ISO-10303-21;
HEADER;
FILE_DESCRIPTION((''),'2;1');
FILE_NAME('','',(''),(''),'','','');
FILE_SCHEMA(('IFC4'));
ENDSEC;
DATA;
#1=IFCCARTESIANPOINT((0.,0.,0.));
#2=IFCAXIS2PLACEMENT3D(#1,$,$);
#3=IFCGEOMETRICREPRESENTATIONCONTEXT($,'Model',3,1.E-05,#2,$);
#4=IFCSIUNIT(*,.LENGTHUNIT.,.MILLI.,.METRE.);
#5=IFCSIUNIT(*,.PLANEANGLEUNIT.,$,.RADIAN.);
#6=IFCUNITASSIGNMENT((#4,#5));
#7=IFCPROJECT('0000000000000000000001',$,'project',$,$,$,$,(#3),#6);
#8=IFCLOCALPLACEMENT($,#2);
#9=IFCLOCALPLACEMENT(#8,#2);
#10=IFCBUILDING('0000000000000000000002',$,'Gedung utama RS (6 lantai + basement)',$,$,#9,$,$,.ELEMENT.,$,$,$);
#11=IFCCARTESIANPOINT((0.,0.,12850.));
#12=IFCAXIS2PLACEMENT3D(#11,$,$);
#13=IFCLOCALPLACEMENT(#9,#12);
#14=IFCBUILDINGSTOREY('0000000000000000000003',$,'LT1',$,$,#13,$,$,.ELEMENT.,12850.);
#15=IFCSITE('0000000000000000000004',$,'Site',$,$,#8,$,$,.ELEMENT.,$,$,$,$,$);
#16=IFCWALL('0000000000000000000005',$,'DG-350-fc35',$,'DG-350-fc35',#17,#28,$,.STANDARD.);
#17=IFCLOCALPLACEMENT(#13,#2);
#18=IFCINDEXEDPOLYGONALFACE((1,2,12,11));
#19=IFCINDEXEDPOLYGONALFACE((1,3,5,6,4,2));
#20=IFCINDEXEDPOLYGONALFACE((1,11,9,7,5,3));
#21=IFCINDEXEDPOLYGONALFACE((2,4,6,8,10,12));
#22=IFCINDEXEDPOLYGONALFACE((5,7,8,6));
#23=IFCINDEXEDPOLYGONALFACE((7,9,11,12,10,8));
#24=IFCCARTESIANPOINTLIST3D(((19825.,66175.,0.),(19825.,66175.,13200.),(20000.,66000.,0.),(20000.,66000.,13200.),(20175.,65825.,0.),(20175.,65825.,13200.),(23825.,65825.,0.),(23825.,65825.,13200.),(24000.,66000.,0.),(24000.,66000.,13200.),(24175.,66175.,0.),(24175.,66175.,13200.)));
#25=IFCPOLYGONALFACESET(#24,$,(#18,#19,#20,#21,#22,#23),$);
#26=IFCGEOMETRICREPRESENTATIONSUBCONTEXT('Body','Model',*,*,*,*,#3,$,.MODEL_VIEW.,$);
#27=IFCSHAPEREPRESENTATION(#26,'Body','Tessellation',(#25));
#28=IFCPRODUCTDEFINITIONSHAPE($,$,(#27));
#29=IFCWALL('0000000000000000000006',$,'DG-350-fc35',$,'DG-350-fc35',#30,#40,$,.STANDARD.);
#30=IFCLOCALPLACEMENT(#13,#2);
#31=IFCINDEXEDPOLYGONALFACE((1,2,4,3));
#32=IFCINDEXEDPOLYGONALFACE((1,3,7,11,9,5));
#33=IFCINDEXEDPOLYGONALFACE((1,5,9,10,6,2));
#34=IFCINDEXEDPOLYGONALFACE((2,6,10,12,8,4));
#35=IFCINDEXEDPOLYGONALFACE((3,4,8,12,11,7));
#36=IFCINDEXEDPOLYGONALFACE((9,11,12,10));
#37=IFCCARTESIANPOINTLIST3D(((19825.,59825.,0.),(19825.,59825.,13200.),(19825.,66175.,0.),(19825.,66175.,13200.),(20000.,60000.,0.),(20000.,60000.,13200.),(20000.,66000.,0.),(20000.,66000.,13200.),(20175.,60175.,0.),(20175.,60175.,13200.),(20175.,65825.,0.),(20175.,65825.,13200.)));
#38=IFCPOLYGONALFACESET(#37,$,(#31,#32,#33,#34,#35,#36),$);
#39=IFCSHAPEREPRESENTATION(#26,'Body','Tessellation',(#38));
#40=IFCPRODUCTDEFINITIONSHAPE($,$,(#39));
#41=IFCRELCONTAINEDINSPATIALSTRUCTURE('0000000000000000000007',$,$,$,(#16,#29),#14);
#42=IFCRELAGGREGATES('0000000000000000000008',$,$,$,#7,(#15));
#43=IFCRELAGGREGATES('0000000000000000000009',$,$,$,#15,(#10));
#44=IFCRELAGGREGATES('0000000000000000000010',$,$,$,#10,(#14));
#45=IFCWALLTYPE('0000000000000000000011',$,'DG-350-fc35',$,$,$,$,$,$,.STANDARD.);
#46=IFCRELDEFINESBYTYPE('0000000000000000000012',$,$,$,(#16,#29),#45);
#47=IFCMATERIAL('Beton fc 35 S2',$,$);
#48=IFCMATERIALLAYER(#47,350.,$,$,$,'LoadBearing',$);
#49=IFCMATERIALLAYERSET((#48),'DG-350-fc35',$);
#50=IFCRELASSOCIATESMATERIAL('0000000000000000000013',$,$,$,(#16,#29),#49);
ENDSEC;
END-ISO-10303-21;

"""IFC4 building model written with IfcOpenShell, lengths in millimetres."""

from ifc_helpers import new_model, si_unit, frame, origin, place, context, subcontext, project, spatial, polyline, outline, extrude, material, layer, layer_set, layer_usage, type_object, element, save


model = new_model("IFC4")

# Units and contexts
model_context = context("Model", 3, precision=1e-05, world=origin())
body_context = subcontext(model_context, "Body", "Model", "MODEL_VIEW")
ifc_project = project(units=[si_unit("LENGTHUNIT", "METRE", prefix="MILLI"), si_unit("PLANEANGLEUNIT", "RADIAN")], contexts=[model_context])

# Site, building, storey
site_placement = place(None, origin())
site = spatial("IfcSite", under=ifc_project, at=site_placement, Name="Site", CompositionType="ELEMENT")
building_placement = place(site_placement, origin())
building = spatial("IfcBuilding", under=site, at=building_placement, Name="Gedung utama RS (6 lantai + basement)", CompositionType="ELEMENT")
storey_placement = place(building_placement, frame((0.0, 0.0, 12850.0)))
storey = spatial("IfcBuildingStorey", under=building, at=storey_placement, Name="LT1", CompositionType="ELEMENT", Elevation=12850.0)

# Walls
ifc_material_1 = material(Name="Beton fc 35 S2")
ifc_layer = layer(ifc_material_1, 350.0, Category="LoadBearing")
ifc_layer_set = layer_set([ifc_layer], Name="DG-350-fc35")
ifc_layer_usage = layer_usage(ifc_layer_set, "AXIS2", "NEGATIVE", 175.0)
wall_type = type_object("IfcWallType", Name="DG-350-fc35", PredefinedType="STANDARD")
wall_1_placement = place(storey_placement, frame((24000.0, 66000.0, 0.0), z_axis=(0.0, 0.0, 1.0), x_axis=(-1.0, 0.0, 0.0)))
element("IfcWall", 1, at=wall_1_placement, inside=storey, type_object=wall_type, material=ifc_layer_usage, Name="DG-350-fc35", ObjectType="DG-350-fc35", PredefinedType="STANDARD", context=body_context, shape_type="SweptSolid", body=[
    extrude(outline(polyline([(-175.0, -175.0), (0.0, 0.0), (175.0, 175.0), (3825.0, 175.0), (4000.0, 0.0), (4175.0, -175.0), (-175.0, -175.0)])), origin(), (0.0, 0.0, 1.0), 13200.0),
])
wall_2_placement = place(storey_placement, frame((20000.0, 66000.0, 0.0), z_axis=(0.0, 0.0, 1.0), x_axis=(0.0, -1.0, 0.0)))
element("IfcWall", 2, at=wall_2_placement, inside=storey, type_object=wall_type, material=ifc_layer_usage, Name="DG-350-fc35", ObjectType="DG-350-fc35", PredefinedType="STANDARD", context=body_context, shape_type="SweptSolid", body=[
    extrude(outline(polyline([(-175.0, -175.0), (0.0, 0.0), (175.0, 175.0), (5825.0, 175.0), (6000.0, 0.0), (6175.0, -175.0), (-175.0, -175.0)])), origin(), (0.0, 0.0, 1.0), 13200.0),
])

save(model, "model.ifc")
